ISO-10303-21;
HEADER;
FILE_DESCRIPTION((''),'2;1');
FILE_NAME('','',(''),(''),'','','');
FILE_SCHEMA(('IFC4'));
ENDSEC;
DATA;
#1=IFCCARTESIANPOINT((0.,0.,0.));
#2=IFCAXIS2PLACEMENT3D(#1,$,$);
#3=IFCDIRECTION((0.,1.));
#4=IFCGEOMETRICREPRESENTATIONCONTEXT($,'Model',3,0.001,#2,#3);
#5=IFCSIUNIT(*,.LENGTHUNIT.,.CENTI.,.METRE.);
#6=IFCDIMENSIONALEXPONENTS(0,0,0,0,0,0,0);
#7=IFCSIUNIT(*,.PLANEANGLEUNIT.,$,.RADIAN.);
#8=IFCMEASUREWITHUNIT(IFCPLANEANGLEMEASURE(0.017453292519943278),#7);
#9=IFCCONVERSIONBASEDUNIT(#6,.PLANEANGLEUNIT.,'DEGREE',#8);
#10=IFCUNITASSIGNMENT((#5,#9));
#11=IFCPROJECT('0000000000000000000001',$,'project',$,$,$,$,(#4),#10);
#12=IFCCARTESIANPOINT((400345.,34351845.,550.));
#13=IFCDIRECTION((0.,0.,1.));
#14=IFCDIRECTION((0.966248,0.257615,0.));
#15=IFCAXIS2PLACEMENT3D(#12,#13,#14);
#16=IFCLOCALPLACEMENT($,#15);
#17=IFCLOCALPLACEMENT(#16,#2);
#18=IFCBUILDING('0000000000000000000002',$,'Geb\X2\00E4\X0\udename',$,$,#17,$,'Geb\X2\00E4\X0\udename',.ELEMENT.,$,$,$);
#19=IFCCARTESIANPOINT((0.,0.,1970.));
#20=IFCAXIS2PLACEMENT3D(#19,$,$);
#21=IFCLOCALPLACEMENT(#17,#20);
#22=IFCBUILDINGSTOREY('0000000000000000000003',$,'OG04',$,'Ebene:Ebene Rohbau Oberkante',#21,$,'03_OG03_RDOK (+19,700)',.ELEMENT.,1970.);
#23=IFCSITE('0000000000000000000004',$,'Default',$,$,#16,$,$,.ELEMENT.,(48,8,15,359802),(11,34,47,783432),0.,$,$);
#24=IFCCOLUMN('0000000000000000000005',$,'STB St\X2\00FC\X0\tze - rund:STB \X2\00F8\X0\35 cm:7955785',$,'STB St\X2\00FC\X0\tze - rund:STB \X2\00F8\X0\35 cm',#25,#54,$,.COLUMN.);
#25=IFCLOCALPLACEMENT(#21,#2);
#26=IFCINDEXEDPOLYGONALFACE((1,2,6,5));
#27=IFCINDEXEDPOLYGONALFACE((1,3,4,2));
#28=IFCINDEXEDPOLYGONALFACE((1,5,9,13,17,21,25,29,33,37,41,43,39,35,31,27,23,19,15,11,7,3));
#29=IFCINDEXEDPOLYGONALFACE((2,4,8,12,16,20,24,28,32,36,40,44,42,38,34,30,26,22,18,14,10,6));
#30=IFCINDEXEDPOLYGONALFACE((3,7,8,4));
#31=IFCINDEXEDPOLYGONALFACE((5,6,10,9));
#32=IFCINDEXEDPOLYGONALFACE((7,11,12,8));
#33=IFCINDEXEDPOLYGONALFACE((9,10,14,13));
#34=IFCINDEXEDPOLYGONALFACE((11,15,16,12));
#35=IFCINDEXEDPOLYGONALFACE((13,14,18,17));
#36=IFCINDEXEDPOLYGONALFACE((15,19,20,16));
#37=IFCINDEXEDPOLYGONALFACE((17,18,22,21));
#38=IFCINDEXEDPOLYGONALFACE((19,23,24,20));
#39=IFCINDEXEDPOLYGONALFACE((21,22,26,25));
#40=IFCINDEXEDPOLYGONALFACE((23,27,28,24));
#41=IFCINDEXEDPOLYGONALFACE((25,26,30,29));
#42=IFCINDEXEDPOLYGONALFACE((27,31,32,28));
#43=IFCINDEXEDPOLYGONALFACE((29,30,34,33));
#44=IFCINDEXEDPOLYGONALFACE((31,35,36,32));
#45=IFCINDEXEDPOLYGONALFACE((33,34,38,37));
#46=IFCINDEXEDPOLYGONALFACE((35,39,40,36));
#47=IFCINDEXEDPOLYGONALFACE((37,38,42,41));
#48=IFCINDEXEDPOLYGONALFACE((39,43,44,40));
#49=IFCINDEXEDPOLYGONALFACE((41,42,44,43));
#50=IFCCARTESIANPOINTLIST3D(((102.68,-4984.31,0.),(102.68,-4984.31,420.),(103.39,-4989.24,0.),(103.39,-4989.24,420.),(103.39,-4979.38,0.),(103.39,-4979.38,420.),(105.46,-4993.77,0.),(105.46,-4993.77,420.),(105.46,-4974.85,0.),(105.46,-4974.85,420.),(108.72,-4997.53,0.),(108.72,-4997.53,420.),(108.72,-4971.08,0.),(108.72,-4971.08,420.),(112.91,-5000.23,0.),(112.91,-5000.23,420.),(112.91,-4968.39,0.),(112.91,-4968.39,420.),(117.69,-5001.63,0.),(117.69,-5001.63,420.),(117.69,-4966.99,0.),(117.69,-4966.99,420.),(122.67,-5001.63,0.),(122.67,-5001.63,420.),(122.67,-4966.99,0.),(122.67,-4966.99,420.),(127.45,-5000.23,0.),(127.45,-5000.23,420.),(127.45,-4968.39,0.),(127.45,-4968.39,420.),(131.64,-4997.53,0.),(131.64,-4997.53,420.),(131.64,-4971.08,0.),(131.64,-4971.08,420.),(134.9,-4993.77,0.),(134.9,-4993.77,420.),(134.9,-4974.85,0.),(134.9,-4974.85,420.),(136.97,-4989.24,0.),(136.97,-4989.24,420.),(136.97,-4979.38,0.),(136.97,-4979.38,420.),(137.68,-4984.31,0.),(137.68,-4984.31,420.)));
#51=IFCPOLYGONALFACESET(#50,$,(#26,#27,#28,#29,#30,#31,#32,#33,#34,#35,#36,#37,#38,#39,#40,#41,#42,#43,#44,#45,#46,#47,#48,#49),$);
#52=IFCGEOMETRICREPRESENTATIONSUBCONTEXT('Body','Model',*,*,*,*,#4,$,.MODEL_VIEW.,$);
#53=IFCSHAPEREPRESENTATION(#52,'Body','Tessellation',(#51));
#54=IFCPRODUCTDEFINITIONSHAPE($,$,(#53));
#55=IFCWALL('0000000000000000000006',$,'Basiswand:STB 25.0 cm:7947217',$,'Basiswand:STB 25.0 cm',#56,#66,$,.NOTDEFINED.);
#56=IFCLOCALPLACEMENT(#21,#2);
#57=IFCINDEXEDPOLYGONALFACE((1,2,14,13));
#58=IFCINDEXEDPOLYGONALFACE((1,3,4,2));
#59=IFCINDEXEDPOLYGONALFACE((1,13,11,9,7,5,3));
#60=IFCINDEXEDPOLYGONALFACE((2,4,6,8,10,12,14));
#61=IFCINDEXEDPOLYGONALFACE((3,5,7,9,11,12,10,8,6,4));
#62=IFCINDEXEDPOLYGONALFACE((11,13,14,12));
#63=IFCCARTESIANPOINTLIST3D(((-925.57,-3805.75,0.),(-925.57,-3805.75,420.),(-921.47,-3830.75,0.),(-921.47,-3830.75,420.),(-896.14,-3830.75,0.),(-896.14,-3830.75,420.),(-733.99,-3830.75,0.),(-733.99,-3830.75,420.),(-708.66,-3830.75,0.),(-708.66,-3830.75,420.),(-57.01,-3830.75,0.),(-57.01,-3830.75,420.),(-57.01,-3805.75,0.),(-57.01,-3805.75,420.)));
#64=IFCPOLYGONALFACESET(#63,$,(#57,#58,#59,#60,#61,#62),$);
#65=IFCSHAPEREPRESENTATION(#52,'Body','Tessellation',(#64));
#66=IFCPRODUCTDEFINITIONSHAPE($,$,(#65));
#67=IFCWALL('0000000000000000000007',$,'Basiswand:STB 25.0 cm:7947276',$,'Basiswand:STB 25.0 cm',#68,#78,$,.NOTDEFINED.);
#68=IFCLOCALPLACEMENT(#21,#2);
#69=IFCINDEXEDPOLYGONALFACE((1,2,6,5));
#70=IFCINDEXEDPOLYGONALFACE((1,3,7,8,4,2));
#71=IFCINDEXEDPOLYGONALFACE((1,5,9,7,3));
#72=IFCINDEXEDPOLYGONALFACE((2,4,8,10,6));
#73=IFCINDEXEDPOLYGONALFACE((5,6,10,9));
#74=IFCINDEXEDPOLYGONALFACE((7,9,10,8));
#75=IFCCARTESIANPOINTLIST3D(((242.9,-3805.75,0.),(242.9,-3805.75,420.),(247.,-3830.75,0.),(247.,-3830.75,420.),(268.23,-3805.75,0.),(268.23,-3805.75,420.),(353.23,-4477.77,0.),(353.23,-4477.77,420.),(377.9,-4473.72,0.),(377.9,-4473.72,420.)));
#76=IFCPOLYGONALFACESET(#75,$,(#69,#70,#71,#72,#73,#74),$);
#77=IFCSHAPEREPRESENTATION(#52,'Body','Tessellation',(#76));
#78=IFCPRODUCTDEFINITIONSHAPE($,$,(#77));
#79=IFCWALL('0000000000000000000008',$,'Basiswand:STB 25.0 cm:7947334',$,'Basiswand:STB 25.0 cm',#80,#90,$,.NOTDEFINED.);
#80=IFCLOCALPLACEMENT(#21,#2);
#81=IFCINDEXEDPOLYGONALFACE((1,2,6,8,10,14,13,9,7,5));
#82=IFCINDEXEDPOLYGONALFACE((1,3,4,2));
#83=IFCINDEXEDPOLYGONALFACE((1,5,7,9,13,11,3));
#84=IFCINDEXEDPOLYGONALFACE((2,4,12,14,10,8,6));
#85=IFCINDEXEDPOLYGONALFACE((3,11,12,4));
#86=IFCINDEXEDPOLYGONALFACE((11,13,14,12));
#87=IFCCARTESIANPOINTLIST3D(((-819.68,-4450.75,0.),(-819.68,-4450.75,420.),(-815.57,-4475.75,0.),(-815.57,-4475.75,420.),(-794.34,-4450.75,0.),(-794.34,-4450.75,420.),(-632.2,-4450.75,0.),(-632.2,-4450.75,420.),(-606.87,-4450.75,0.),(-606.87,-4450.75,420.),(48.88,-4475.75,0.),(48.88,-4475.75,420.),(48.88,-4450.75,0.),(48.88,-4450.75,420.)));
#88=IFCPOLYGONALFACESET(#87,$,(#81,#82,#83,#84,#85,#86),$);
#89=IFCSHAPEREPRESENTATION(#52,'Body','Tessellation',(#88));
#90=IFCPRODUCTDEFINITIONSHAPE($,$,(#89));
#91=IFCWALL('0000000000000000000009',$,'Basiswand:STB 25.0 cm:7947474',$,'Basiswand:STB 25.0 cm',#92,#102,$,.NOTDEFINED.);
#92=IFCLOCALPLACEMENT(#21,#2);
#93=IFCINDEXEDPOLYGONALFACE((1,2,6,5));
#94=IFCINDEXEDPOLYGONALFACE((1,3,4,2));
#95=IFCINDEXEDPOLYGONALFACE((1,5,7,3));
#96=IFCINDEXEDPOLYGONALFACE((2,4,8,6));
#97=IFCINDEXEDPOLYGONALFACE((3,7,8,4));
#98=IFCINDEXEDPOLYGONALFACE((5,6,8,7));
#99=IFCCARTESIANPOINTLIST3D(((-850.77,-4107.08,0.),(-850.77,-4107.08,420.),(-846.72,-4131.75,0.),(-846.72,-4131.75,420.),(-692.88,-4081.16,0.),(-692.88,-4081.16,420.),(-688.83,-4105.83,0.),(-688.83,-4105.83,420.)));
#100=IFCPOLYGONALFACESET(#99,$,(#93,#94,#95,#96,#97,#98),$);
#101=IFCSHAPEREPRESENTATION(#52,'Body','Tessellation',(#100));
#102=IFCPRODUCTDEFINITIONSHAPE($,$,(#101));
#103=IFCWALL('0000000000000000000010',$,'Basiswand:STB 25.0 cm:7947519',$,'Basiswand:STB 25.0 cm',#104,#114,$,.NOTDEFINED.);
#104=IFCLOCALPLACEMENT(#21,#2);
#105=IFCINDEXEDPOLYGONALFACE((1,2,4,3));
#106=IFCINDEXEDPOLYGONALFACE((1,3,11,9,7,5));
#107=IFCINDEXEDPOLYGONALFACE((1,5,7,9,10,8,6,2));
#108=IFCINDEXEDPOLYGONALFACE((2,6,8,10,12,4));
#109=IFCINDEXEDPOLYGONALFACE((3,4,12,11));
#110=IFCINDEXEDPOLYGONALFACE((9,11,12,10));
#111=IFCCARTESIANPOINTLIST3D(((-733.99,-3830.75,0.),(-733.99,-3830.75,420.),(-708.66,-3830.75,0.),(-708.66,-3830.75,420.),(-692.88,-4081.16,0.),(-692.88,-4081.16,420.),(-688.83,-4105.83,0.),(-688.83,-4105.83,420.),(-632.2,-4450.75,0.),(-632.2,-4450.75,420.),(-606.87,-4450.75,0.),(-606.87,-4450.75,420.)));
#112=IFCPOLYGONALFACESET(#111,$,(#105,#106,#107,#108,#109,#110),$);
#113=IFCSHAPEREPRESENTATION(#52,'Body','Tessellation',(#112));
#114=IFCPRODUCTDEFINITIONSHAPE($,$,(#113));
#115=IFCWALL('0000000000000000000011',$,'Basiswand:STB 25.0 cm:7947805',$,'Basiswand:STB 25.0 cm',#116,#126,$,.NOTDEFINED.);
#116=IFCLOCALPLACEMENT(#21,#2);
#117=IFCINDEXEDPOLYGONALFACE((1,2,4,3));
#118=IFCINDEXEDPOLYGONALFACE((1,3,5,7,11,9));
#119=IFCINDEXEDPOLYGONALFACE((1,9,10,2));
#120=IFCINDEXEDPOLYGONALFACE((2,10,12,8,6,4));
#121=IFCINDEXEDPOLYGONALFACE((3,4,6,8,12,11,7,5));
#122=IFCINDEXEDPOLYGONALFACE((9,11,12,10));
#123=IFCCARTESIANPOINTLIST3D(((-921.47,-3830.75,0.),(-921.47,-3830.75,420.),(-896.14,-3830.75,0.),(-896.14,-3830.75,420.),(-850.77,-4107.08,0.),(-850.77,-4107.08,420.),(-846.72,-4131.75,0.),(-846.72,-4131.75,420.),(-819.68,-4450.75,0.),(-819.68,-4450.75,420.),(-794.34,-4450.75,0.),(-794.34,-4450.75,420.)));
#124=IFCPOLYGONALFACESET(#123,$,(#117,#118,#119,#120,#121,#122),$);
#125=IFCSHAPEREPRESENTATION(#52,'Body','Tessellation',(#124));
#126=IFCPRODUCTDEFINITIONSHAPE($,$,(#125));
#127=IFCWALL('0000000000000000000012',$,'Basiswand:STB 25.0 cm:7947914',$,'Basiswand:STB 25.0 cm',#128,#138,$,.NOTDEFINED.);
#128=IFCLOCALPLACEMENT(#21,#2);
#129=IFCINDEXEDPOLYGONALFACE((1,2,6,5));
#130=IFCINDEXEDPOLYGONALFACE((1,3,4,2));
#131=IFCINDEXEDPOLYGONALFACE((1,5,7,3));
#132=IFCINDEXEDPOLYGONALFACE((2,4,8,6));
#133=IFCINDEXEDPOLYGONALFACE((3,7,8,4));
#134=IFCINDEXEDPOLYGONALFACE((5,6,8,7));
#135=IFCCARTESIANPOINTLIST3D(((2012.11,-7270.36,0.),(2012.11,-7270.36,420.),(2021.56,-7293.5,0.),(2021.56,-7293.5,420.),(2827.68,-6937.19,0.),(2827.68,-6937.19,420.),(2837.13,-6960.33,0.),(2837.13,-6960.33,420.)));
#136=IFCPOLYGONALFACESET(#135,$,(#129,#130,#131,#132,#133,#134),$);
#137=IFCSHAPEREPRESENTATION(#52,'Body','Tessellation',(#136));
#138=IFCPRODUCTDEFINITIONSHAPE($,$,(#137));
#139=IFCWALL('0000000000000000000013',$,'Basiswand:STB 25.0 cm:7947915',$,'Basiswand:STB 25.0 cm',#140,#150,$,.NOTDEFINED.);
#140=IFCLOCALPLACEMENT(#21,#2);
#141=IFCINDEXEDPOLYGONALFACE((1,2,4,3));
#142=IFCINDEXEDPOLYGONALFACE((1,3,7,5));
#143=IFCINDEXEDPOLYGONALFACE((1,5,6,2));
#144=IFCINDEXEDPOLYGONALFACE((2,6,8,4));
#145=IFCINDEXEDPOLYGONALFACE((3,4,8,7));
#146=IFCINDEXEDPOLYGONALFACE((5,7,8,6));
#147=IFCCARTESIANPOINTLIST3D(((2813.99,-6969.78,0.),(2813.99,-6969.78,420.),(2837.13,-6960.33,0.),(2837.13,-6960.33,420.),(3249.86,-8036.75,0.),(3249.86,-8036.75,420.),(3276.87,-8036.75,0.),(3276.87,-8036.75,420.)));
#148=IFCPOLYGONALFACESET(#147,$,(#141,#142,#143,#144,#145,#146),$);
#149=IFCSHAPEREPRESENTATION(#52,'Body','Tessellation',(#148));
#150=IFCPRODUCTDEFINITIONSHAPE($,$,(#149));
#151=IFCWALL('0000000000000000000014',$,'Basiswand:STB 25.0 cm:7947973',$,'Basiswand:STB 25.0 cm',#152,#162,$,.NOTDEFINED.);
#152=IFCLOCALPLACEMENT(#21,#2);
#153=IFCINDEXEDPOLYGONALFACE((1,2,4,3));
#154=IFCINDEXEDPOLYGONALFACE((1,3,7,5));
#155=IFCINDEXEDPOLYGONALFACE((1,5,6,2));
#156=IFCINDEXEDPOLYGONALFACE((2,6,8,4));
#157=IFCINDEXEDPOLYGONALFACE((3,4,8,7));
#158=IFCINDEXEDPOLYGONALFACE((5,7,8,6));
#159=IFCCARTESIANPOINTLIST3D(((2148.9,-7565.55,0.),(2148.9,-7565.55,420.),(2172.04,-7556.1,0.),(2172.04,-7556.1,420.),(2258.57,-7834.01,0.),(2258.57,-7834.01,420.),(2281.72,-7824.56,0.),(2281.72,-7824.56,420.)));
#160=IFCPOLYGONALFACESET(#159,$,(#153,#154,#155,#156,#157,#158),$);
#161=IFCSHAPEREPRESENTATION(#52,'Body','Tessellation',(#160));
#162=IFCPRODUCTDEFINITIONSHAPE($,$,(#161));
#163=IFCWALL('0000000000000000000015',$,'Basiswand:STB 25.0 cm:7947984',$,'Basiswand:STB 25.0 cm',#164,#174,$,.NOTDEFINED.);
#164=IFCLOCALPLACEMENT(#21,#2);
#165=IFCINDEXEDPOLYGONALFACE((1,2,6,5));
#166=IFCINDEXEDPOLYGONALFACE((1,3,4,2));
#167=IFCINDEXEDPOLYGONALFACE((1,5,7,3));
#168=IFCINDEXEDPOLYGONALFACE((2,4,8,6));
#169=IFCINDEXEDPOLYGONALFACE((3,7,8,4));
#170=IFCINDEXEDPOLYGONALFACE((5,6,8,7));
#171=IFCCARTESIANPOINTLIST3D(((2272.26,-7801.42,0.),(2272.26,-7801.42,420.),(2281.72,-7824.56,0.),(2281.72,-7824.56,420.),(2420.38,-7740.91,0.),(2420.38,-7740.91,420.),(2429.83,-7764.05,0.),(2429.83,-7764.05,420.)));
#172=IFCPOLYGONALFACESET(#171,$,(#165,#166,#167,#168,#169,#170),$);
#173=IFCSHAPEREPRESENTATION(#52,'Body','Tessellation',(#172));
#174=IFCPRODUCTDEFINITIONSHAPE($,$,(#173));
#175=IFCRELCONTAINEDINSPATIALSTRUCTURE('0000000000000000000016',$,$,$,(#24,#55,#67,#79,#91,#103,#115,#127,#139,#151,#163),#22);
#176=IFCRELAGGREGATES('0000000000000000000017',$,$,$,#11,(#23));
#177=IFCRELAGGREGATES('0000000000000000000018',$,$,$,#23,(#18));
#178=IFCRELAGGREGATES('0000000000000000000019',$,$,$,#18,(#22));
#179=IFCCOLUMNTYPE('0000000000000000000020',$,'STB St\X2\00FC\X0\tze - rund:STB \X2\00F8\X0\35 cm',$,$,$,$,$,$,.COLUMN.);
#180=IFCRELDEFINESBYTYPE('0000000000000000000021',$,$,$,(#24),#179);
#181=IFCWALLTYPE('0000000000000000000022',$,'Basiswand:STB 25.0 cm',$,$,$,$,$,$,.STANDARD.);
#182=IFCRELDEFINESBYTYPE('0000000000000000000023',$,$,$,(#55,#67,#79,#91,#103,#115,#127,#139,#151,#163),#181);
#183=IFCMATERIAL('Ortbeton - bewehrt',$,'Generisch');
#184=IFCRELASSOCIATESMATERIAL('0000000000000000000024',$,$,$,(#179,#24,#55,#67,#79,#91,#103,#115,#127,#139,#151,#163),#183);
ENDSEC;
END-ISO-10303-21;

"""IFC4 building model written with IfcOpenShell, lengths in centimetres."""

from ifc_helpers import new_model, entity, si_unit, converted_unit, direction, frame, origin, place, context, subcontext, project, spatial, arc, indexed_curve, outline, extrude, source, transform, mapped, material, type_object, type_shapes, element, save


model = new_model("IFC4")

# Units and contexts
model_context = context("Model", 3, precision=0.001, world=origin(), true_north=direction((0.0, 1.0)))
body_context = subcontext(model_context, "Body", "Model", "MODEL_VIEW")
ifc_project = project(units=[si_unit("LENGTHUNIT", "METRE", prefix="CENTI"), converted_unit("PLANEANGLEUNIT", "DEGREE", entity("IfcPlaneAngleMeasure", 0.017453292519943278), si_unit("PLANEANGLEUNIT", "RADIAN"), dimensions=[0, 0, 0, 0, 0, 0, 0])], contexts=[model_context])

# Site, building, storey
site_placement = place(None, frame((400345.0, 34351845.0, 550.0), z_axis=(0.0, 0.0, 1.0), x_axis=(0.966248, 0.257615, 0.0)))
site = spatial("IfcSite", under=ifc_project, at=site_placement, Name="Default", CompositionType="ELEMENT", RefLatitude=(48, 8, 15, 359802), RefLongitude=(11, 34, 47, 783432), RefElevation=0.0)
building_placement = place(site_placement, origin())
building = spatial("IfcBuilding", under=site, at=building_placement, Name="Gebäudename", LongName="Gebäudename", CompositionType="ELEMENT")
storey_placement = place(building_placement, frame((0.0, 0.0, 1970.0)))
storey = spatial("IfcBuildingStorey", under=building, at=storey_placement, Name="OG04", ObjectType="Ebene:Ebene Rohbau Oberkante", LongName="03_OG03_RDOK (+19,700)", CompositionType="ELEMENT", Elevation=1970.0)

# Column
ifc_material = material(Name="Ortbeton - bewehrt", Category="Generisch")
column_type_1 = type_object("IfcColumnType", Name="STB Stütze - rund:STB ø35 cm", PredefinedType="COLUMN", material=ifc_material)
shared_shape_1 = source(origin(), body_context, "Body", "SweptSolid", [
    extrude(outline(indexed_curve([(-17.5, 0.0), (0.0, -17.5), (17.5, 0.0), (0.0, 17.5)], segments=[arc(1, 2, 3), arc(3, 4, 1)], self_intersect=False)), frame((120.18, -4984.31, 1970.0)), (0.0, 0.0, 1.0), 420.0),
])
type_shapes(column_type_1, [shared_shape_1])
column_1_placement = place(storey_placement, frame((0.0, 0.0, -1970.0)))
element("IfcColumn", 1, at=column_1_placement, inside=storey, type_object=column_type_1, material=ifc_material, Name="STB Stütze - rund:STB ø35 cm:7955785", ObjectType="STB Stütze - rund:STB ø35 cm", PredefinedType="COLUMN", context=body_context, shape_type="MappedRepresentation", body=[
    mapped(shared_shape_1, transform((0.0, 0.0, 0.0), scale=1.0)),
])

# Walls
wall_type = type_object("IfcWallType", Name="Basiswand:STB 25.0 cm", PredefinedType="STANDARD")
wall_1_placement = place(storey_placement, frame((-925.57, -3818.25, 0.0)))
element("IfcWall", 2, at=wall_1_placement, inside=storey, type_object=wall_type, material=ifc_material, Name="Basiswand:STB 25.0 cm:7947217", ObjectType="Basiswand:STB 25.0 cm", PredefinedType="NOTDEFINED", context=body_context, shape_type="SweptSolid", body=[
    extrude(outline(indexed_curve([(868.56, -12.5), (868.56, 12.5), (0.0, 12.5), (4.1, -12.5), (29.44, -12.5), (191.58, -12.5), (216.92, -12.5), (868.56, -12.5)], self_intersect=False)), origin(), (0.0, 0.0, 1.0), 420.0),
])
wall_2_placement = place(storey_placement, frame((255.23, -3803.72, 0.0), z_axis=(0.0, 0.0, 1.0), x_axis=(0.162011, -0.986789, 0.0)))
element("IfcWall", 3, at=wall_2_placement, inside=storey, type_object=wall_type, material=ifc_material, Name="Basiswand:STB 25.0 cm:7947276", ObjectType="Basiswand:STB 25.0 cm", PredefinedType="NOTDEFINED", context=body_context, shape_type="SweptSolid", body=[
    extrude(outline(indexed_curve([(681.02, -12.5), (681.02, 12.5), (4.1, 12.5), (0.0, -12.5), (25.33, -12.5), (681.02, -12.5)], self_intersect=False)), origin(), (0.0, 0.0, 1.0), 420.0),
])
wall_3_placement = place(storey_placement, frame((48.88, -4463.25, 0.0), z_axis=(0.0, 0.0, 1.0), x_axis=(-1.0, 0.0, 0.0)))
element("IfcWall", 4, at=wall_3_placement, inside=storey, type_object=wall_type, material=ifc_material, Name="Basiswand:STB 25.0 cm:7947334", ObjectType="Basiswand:STB 25.0 cm", PredefinedType="NOTDEFINED", context=body_context, shape_type="SweptSolid", body=[
    extrude(outline(indexed_curve([(868.56, -12.5), (864.46, 12.5), (0.0, 12.5), (0.0, -12.5), (655.75, -12.5), (681.08, -12.5), (843.23, -12.5), (868.56, -12.5)], self_intersect=False)), origin(), (0.0, 0.0, 1.0), 420.0),
])
wall_4_placement = place(storey_placement, frame((-848.74, -4119.42, 0.0), z_axis=(0.0, 0.0, 1.0), x_axis=(0.986789, 0.162011, 0.0)))
element("IfcWall", 5, at=wall_4_placement, inside=storey, type_object=wall_type, material=ifc_material, Name="Basiswand:STB 25.0 cm:7947474", ObjectType="Basiswand:STB 25.0 cm", PredefinedType="NOTDEFINED", context=body_context, shape_type="SweptSolid", body=[
    extrude(outline(indexed_curve([(160.0, 12.5), (0.0, 12.5), (0.0, -12.5), (160.0, -12.5), (160.0, 12.5)], self_intersect=False)), origin(), (0.0, 0.0, 1.0), 420.0),
])
wall_5_placement = place(storey_placement, frame((-721.66, -3828.72, 0.0), z_axis=(0.0, 0.0, 1.0), x_axis=(0.162011, -0.986789, 0.0)))
element("IfcWall", 6, at=wall_5_placement, inside=storey, type_object=wall_type, material=ifc_material, Name="Basiswand:STB 25.0 cm:7947519", ObjectType="Basiswand:STB 25.0 cm", PredefinedType="NOTDEFINED", context=body_context, shape_type="SweptSolid", body=[
    extrude(outline(indexed_curve([(4.1, 12.5), (0.0, -12.5), (253.77, -12.5), (278.77, -12.5), (628.3, -12.5), (632.41, 12.5), (4.1, 12.5)], self_intersect=False)), origin(), (0.0, 0.0, 1.0), 420.0),
])
wall_6_placement = place(storey_placement, frame((-806.68, -4452.77, 0.0), z_axis=(0.0, 0.0, 1.0), x_axis=(-0.162011, 0.986789, 0.0)))
element("IfcWall", 7, at=wall_6_placement, inside=storey, type_object=wall_type, material=ifc_material, Name="Basiswand:STB 25.0 cm:7947805", ObjectType="Basiswand:STB 25.0 cm", PredefinedType="NOTDEFINED", context=body_context, shape_type="SweptSolid", body=[
    extrude(outline(indexed_curve([(628.3, -12.5), (632.41, 12.5), (4.1, 12.5), (0.0, -12.5), (323.26, -12.5), (348.26, -12.5), (628.3, -12.5)], self_intersect=False)), origin(), (0.0, 0.0, 1.0), 420.0),
])
wall_7_placement = place(storey_placement, frame((2016.84, -7281.93, 0.0), z_axis=(0.0, 0.0, 1.0), x_axis=(0.925734, 0.378175, 0.0)))
element("IfcWall", 8, at=wall_7_placement, inside=storey, type_object=wall_type, material=ifc_material, Name="Basiswand:STB 25.0 cm:7947914", ObjectType="Basiswand:STB 25.0 cm", PredefinedType="NOTDEFINED", context=body_context, shape_type="SweptSolid", body=[
    extrude(outline(indexed_curve([(881.0, 12.5), (0.0, 12.5), (0.0, -12.5), (881.0, -12.5), (881.0, 12.5)], self_intersect=False)), origin(), (0.0, 0.0, 1.0), 420.0),
])
wall_8_placement = place(storey_placement, frame((2825.56, -6965.06, 0.0), z_axis=(0.0, 0.0, 1.0), x_axis=(0.378175, -0.925734, 0.0)))
element("IfcWall", 9, at=wall_8_placement, inside=storey, type_object=wall_type, material=ifc_material, Name="Basiswand:STB 25.0 cm:7947915", ObjectType="Basiswand:STB 25.0 cm", PredefinedType="NOTDEFINED", context=body_context, shape_type="SweptSolid", body=[
    extrude(outline(indexed_curve([(1152.56, -12.5), (1162.77, 12.5), (0.0, 12.5), (0.0, -12.5), (1152.56, -12.5)], self_intersect=False)), origin(), (0.0, 0.0, 1.0), 420.0),
])
wall_9_placement = place(storey_placement, frame((2160.47, -7560.82, 0.0), z_axis=(0.0, 0.0, 1.0), x_axis=(0.378175, -0.925734, 0.0)))
element("IfcWall", 10, at=wall_9_placement, inside=storey, type_object=wall_type, material=ifc_material, Name="Basiswand:STB 25.0 cm:7947973", ObjectType="Basiswand:STB 25.0 cm", PredefinedType="NOTDEFINED", context=body_context, shape_type="SweptSolid", body=[
    extrude(outline(indexed_curve([(290.0, 12.5), (0.0, 12.5), (0.0, -12.5), (290.0, -12.5), (290.0, 12.5)], self_intersect=False)), origin(), (0.0, 0.0, 1.0), 420.0),
])
wall_10_placement = place(storey_placement, frame((2276.99, -7812.99, 0.0), z_axis=(0.0, 0.0, 1.0), x_axis=(0.925734, 0.378175, 0.0)))
element("IfcWall", 11, at=wall_10_placement, inside=storey, type_object=wall_type, material=ifc_material, Name="Basiswand:STB 25.0 cm:7947984", ObjectType="Basiswand:STB 25.0 cm", PredefinedType="NOTDEFINED", context=body_context, shape_type="SweptSolid", body=[
    extrude(outline(indexed_curve([(160.0, 12.5), (0.0, 12.5), (0.0, -12.5), (160.0, -12.5), (160.0, 12.5)], self_intersect=False)), origin(), (0.0, 0.0, 1.0), 420.0),
])

save(model, "model.ifc")
